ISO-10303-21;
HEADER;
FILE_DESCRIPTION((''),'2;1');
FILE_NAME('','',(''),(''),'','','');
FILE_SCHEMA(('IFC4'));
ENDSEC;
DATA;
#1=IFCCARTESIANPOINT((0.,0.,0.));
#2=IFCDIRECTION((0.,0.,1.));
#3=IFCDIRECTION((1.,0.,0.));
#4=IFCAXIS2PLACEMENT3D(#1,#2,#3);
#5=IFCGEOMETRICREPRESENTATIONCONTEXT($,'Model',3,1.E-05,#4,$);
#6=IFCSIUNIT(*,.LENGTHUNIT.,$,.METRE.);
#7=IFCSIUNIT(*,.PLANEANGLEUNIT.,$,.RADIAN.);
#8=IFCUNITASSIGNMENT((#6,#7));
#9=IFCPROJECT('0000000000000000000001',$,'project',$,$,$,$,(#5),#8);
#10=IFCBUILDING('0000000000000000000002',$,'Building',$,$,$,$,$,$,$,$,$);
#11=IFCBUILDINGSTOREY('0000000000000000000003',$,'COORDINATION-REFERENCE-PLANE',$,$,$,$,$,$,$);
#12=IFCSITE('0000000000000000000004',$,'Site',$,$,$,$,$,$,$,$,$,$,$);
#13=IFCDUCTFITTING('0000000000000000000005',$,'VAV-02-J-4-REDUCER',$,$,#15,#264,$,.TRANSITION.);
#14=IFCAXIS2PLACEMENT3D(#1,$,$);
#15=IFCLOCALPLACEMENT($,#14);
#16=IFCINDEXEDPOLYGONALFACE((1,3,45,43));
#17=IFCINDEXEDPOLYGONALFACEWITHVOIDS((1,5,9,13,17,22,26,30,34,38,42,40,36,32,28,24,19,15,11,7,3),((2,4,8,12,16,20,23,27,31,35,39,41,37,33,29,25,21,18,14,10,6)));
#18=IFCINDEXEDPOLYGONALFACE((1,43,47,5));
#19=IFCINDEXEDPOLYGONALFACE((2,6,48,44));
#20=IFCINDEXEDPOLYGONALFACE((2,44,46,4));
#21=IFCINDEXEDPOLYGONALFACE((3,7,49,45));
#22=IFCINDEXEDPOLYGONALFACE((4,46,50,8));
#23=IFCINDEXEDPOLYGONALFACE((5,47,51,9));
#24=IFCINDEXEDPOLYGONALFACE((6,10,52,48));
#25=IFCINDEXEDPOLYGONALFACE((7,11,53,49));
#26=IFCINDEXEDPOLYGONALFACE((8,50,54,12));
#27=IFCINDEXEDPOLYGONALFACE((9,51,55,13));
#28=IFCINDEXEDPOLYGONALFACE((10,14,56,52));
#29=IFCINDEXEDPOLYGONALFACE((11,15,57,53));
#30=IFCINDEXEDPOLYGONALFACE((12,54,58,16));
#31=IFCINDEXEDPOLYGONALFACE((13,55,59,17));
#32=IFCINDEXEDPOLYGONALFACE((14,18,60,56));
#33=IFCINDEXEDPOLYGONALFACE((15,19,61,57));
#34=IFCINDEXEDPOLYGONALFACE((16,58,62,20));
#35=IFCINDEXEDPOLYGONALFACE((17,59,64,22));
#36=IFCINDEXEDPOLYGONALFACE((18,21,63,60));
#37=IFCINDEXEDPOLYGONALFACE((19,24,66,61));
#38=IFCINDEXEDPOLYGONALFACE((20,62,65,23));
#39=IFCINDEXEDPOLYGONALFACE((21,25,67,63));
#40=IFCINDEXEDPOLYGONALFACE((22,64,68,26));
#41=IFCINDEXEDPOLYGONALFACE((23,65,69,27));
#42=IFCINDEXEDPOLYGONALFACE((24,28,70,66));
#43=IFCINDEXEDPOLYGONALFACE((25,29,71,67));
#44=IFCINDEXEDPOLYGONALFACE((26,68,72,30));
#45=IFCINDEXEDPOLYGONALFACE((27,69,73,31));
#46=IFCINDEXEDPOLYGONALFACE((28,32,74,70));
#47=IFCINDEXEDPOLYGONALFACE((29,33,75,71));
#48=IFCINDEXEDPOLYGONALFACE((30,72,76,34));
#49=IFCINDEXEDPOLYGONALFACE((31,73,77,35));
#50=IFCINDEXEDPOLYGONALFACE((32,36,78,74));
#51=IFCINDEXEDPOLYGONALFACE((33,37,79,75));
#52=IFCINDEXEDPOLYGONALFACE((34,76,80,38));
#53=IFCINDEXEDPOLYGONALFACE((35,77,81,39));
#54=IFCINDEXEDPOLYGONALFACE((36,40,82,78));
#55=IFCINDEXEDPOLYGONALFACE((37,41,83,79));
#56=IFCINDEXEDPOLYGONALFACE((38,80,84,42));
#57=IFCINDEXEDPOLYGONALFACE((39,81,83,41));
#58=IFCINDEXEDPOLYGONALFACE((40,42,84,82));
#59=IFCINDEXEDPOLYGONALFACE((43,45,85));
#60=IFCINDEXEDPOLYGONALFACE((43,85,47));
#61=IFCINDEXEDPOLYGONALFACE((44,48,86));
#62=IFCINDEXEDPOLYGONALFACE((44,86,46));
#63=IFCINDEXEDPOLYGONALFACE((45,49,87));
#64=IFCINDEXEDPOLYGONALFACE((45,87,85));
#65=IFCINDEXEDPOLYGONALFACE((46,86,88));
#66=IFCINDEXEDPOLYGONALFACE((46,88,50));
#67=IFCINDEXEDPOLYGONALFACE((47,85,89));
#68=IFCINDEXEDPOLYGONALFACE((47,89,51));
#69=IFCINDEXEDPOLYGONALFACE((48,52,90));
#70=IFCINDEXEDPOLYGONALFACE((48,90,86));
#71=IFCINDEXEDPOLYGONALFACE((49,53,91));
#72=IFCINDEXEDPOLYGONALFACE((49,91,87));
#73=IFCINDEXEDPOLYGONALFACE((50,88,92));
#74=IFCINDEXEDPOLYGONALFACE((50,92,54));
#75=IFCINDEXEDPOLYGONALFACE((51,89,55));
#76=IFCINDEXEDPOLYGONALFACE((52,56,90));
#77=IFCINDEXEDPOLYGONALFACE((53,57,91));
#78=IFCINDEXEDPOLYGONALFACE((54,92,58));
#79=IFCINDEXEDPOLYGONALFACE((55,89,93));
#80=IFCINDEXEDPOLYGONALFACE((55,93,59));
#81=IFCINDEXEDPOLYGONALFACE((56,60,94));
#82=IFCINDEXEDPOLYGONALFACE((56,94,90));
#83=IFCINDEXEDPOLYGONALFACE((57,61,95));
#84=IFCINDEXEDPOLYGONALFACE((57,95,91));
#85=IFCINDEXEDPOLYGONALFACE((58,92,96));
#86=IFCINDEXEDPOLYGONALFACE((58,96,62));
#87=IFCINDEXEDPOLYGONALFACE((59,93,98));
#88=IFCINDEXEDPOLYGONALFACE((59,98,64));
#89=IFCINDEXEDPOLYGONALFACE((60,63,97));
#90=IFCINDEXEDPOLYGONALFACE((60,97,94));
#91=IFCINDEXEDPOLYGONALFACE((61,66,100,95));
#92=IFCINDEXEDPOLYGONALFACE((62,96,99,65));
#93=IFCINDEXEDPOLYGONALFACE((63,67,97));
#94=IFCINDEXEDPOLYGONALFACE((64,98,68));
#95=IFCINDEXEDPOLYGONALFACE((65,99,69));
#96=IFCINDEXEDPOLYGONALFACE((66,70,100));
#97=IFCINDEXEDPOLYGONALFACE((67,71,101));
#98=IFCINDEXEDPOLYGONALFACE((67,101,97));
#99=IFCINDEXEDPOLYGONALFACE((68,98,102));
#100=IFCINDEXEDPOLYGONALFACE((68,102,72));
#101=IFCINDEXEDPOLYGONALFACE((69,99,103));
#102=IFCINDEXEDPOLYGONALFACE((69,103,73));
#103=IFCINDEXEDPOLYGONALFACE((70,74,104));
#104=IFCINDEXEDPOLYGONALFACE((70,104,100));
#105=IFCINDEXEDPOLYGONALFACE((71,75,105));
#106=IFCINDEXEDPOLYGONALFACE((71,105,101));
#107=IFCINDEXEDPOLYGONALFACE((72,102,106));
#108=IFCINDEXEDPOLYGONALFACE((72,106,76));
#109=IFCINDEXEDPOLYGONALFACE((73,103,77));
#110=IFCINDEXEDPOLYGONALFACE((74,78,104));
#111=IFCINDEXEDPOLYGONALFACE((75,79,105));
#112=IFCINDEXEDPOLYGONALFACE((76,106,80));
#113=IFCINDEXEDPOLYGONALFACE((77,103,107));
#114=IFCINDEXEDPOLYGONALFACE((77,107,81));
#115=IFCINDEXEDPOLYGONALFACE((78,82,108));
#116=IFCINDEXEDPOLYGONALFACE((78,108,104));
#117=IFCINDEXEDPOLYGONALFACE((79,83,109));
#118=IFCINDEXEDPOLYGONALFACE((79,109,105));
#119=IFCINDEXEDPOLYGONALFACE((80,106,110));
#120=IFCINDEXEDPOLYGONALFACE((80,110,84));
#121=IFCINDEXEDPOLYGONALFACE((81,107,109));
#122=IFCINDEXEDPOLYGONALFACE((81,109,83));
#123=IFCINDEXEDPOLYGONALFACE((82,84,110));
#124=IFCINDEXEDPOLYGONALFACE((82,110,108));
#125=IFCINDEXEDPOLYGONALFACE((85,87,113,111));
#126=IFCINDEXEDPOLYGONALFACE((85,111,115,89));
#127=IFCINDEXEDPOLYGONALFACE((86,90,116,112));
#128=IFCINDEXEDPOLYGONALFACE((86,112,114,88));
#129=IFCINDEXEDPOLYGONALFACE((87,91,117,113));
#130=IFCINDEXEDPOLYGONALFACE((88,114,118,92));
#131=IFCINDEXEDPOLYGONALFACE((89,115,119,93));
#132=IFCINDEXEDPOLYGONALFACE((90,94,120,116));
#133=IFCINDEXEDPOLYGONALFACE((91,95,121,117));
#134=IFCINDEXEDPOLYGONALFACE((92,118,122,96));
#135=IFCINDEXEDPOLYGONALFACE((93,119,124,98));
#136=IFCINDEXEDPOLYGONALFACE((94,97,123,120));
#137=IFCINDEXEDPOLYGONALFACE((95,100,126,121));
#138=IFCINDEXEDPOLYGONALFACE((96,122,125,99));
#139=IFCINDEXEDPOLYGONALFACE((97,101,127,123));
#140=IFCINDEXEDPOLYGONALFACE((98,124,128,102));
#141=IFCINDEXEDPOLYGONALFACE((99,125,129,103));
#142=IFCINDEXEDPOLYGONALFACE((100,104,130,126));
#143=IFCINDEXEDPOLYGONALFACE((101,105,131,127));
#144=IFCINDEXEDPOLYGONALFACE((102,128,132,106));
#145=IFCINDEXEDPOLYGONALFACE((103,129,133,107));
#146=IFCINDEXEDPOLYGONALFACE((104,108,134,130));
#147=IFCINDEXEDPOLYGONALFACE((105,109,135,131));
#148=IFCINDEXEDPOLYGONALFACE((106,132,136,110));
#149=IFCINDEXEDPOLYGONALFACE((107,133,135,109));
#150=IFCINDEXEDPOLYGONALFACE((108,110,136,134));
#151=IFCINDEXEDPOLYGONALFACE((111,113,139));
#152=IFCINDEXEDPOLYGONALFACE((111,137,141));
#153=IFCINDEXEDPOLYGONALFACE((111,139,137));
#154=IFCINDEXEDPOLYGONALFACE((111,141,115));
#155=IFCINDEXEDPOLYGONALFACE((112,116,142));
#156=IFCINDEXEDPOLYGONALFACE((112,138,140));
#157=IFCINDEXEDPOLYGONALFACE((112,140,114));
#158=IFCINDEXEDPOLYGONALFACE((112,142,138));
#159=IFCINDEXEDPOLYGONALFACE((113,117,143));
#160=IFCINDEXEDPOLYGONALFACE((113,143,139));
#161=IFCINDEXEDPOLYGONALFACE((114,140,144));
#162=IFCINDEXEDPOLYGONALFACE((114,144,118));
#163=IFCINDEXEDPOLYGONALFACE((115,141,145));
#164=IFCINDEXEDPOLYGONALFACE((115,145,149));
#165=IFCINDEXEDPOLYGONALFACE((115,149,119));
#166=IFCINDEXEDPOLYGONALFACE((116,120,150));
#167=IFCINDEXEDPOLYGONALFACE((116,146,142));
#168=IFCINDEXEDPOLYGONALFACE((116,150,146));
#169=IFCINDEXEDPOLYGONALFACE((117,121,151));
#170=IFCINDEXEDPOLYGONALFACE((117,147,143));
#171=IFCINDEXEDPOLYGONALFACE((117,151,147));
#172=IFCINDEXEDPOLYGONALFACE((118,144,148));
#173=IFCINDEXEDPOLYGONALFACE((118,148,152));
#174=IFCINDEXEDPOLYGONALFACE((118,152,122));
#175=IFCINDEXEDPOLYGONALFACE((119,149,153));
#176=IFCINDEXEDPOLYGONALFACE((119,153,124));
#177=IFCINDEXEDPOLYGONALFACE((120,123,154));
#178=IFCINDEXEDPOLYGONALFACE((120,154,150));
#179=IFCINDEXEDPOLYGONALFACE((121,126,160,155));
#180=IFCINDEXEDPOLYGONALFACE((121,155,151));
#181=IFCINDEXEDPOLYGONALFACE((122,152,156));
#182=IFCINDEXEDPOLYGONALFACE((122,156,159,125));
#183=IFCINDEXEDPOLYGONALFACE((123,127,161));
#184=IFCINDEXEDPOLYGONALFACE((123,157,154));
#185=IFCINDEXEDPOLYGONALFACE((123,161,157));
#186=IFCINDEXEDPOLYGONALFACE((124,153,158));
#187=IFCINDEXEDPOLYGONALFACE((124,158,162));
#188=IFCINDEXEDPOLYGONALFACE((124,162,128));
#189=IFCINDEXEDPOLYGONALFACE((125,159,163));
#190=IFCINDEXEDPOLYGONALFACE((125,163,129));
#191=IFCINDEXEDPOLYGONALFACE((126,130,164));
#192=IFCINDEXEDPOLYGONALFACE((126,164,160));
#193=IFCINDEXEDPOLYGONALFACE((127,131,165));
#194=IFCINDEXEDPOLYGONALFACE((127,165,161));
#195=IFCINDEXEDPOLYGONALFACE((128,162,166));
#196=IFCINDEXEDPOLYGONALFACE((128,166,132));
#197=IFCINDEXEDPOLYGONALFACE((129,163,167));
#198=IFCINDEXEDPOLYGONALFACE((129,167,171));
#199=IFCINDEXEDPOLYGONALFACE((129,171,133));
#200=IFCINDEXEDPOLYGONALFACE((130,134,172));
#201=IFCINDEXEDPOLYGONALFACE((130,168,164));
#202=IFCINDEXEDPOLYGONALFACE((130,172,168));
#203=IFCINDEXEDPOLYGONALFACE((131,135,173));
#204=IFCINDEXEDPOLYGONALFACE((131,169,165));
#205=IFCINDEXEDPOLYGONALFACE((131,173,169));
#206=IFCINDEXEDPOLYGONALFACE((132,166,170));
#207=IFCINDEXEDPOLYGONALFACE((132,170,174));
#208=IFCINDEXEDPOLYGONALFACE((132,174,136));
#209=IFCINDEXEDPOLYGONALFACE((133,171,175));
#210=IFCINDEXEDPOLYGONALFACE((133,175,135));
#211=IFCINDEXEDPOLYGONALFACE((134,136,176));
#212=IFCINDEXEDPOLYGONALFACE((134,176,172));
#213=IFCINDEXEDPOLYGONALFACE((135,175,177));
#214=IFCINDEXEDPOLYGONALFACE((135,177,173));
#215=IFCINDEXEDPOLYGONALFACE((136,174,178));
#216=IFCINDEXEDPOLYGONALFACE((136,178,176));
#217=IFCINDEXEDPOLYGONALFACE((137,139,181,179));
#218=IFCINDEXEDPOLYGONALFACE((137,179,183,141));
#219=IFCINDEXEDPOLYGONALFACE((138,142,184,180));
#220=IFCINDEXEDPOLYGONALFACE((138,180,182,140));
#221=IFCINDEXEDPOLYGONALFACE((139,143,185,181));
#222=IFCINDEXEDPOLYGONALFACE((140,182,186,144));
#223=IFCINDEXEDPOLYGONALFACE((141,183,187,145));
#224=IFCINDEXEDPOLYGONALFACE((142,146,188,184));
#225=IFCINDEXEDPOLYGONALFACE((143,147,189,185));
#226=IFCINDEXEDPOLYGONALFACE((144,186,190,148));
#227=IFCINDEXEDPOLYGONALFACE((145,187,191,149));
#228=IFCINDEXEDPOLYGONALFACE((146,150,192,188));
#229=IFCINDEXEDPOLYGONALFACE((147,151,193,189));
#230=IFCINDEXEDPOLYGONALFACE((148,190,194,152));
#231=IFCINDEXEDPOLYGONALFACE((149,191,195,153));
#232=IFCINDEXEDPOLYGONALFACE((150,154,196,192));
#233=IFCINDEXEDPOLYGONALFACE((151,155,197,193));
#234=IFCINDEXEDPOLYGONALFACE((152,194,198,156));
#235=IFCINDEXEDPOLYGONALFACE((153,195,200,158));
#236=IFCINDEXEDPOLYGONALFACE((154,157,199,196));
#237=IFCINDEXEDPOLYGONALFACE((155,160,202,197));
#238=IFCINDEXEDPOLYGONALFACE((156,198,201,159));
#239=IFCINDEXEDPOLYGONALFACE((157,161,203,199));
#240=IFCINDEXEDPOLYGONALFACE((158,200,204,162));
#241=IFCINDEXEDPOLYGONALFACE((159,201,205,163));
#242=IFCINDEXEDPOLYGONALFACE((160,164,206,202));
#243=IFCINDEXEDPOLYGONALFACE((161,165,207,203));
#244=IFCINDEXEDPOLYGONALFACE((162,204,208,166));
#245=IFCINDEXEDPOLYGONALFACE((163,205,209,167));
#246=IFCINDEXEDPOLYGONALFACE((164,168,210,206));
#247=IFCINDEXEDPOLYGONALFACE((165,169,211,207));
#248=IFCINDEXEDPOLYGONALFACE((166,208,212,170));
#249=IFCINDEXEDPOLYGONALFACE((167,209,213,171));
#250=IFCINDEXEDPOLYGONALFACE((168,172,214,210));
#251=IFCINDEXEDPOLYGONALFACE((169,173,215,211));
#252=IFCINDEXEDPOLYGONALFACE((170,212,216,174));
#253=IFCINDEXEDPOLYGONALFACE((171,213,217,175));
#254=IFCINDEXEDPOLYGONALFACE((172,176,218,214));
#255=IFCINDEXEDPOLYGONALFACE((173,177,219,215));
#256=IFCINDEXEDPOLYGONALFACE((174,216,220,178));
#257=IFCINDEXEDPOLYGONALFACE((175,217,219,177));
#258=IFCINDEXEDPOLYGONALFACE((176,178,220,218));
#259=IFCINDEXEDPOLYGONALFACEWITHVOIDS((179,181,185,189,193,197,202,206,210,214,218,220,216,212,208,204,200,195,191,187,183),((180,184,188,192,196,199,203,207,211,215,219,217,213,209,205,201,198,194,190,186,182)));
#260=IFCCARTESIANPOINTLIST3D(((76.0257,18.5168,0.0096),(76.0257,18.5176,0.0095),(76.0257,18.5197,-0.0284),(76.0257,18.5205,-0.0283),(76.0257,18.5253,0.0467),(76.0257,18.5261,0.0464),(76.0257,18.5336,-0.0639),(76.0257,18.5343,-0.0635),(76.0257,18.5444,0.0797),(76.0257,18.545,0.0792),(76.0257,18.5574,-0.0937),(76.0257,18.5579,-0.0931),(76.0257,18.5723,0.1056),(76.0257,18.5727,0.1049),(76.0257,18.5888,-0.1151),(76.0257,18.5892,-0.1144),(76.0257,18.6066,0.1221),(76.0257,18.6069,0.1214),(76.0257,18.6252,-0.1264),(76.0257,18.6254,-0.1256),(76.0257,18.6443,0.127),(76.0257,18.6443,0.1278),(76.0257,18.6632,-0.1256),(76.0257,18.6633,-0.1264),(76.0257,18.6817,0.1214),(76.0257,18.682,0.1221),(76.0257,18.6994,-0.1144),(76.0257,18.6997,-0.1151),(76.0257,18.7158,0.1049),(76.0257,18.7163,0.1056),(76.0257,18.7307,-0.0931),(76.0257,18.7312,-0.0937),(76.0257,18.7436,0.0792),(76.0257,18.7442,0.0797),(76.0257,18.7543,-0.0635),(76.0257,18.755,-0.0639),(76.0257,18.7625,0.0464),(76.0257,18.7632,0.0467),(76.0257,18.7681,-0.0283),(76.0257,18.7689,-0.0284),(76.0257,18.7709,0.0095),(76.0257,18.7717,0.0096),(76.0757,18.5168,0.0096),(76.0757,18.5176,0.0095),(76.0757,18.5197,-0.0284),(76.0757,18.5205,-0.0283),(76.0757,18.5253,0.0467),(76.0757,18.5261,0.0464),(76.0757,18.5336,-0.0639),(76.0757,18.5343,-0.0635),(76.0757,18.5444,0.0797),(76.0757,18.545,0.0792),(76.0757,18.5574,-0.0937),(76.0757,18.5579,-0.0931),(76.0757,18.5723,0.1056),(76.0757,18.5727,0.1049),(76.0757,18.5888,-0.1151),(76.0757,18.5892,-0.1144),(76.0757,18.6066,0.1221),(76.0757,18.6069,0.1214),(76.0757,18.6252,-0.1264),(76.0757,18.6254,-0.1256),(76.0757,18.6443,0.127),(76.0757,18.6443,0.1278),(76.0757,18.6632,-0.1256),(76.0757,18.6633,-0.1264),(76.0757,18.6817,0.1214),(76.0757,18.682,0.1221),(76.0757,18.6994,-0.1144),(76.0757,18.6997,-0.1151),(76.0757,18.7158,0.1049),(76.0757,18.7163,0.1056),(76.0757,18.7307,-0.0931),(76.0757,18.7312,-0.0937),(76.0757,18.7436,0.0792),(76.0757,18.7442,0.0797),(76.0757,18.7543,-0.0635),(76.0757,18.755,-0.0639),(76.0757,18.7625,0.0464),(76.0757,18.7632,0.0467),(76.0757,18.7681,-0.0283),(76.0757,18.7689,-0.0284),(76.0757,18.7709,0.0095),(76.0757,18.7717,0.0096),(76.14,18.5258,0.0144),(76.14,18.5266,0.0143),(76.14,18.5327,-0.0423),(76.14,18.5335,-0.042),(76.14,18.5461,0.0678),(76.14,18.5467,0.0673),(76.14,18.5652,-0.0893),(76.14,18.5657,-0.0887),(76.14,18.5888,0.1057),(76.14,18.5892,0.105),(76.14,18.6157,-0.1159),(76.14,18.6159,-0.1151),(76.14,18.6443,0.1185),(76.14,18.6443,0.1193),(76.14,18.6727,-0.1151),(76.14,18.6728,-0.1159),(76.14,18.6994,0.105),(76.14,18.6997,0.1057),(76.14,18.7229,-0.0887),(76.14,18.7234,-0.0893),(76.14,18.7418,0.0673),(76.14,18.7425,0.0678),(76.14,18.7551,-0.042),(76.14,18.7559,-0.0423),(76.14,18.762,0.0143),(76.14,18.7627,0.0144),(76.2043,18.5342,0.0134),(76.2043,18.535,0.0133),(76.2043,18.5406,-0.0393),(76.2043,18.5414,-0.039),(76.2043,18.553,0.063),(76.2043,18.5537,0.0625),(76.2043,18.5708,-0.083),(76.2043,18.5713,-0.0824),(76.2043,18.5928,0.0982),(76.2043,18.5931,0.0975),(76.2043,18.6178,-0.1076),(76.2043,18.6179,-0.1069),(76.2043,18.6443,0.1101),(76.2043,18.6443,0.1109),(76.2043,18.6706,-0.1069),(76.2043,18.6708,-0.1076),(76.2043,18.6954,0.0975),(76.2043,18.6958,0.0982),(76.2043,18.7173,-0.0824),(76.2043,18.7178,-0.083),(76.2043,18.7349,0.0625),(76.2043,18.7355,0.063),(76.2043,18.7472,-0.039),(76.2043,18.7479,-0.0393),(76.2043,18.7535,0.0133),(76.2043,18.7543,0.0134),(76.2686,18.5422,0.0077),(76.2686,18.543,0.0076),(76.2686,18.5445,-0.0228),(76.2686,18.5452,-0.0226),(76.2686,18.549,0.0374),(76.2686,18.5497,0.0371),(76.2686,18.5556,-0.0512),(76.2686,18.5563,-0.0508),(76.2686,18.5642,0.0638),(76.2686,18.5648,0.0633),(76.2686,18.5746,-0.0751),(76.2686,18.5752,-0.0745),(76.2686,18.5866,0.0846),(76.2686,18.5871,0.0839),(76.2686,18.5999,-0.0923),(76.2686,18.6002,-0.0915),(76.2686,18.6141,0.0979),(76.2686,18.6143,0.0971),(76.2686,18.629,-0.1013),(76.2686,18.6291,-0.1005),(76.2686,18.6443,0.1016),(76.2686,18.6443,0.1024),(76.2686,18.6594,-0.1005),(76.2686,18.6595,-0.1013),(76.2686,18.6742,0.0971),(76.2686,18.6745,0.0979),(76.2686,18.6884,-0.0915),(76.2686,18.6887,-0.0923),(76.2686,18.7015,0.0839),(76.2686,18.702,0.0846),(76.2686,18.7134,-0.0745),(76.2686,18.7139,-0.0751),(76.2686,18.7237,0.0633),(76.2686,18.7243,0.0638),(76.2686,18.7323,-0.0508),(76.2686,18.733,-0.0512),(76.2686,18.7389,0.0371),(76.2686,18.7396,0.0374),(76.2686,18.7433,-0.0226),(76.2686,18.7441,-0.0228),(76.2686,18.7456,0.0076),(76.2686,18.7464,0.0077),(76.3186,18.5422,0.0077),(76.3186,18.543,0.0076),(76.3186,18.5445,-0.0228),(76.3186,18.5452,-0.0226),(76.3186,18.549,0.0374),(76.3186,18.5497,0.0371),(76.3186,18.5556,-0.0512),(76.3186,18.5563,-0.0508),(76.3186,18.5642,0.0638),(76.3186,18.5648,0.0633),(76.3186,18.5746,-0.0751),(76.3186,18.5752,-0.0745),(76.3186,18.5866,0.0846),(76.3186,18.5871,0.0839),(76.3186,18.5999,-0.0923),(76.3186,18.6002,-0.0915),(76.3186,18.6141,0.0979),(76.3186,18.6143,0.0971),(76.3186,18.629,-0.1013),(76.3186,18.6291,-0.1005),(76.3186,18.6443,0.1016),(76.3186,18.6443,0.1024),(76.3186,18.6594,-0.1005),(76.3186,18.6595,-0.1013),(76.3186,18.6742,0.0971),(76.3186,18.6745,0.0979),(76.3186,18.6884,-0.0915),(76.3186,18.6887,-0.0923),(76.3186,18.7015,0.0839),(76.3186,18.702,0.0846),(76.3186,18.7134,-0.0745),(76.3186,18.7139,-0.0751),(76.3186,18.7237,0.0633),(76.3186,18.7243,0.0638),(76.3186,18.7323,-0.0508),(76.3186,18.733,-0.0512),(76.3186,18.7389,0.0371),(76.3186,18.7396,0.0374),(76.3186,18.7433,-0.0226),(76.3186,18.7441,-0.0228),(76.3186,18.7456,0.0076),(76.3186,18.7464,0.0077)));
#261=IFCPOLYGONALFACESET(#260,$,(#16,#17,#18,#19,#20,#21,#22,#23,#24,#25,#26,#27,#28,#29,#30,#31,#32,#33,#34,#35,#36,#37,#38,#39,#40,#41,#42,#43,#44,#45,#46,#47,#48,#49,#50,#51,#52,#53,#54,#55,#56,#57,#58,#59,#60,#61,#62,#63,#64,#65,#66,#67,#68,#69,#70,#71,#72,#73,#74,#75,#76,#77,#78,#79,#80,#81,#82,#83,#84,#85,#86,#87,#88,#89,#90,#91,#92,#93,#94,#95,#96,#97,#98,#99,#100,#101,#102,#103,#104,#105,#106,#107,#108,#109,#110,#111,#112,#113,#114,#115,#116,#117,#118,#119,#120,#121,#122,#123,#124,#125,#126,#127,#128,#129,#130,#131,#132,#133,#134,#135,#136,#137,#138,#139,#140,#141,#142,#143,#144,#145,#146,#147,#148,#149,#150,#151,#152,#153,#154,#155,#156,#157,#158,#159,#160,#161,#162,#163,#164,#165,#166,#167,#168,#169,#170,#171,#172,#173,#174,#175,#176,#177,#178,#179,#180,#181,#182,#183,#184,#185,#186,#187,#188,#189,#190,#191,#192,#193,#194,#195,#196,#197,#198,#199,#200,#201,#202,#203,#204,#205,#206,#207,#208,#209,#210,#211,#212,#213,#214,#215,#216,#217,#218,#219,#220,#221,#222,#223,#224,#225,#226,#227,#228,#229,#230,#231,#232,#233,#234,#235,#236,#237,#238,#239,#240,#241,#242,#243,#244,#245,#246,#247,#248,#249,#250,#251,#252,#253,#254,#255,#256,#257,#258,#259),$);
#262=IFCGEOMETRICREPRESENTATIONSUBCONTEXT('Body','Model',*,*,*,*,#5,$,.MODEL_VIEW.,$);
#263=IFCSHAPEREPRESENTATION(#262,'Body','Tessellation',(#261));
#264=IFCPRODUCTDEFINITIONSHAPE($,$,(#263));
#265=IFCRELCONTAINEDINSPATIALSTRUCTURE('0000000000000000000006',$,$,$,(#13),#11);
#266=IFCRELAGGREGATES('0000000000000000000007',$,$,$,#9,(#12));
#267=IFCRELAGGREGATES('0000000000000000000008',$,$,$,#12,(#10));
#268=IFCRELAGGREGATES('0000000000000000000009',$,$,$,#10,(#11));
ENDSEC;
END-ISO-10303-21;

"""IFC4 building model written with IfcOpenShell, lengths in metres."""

from ifc_helpers import new_model, entity, si_unit, frame, origin_with_axes, place, context, subcontext, project, spatial, element, save


model = new_model("IFC4")

# Units and contexts
model_context = context("Model", 3, precision=1e-05, world=origin_with_axes())
body_context_1 = subcontext(model_context, "Body", "Model", "MODEL_VIEW")
ifc_project = project(units=[si_unit("LENGTHUNIT", "METRE"), si_unit("PLANEANGLEUNIT", "RADIAN")], contexts=[model_context])

# Site, building, storey
site = spatial("IfcSite", under=ifc_project, Name="Site")
building = spatial("IfcBuilding", under=site, Name="Building")
storey = spatial("IfcBuildingStorey", under=building, Name="COORDINATION-REFERENCE-PLANE")

# Duct fitting
for number, where, z_axis, x_axis, name in (
    (1, (76.0257, 18.6443, 0.0), (0.0, 1.0, 0.0), (0.0, 0.0, 1.0), "VAV-02-J-4-REDUCER"),
):
    element("IfcDuctFitting", number, at=place(None, frame(where, z_axis=z_axis, x_axis=x_axis)), inside=storey, Name=name, PredefinedType="TRANSITION", context=body_context_1, shape_type="SweptSolid", body=[
        entity("IfcRevolvedAreaSolid", entity("IfcArbitraryClosedProfileDef", "AREA", None, entity("IfcPolyline", [entity("IfcCartesianPoint", [0.1278, 0.0]), entity("IfcCartesianPoint", [0.1278, 0.05]), entity("IfcCartesianPoint", [0.1024, 0.2429]), entity("IfcCartesianPoint", [0.1024, 0.2929]), entity("IfcCartesianPoint", [0.1016, 0.2929]), entity("IfcCartesianPoint", [0.1016, 0.2429]), entity("IfcCartesianPoint", [0.127, 0.05]), entity("IfcCartesianPoint", [0.127, 0.0]), entity("IfcCartesianPoint", [0.1278, 0.0])])), entity("IfcAxis2Placement3D", entity("IfcCartesianPoint", [0.0, 0.0, 0.0])), entity("IfcAxis1Placement", entity("IfcCartesianPoint", [0.0, 0.0, 0.0]), entity("IfcDirection", [0.0, 1.0, 0.0])), 6.283185),
    ])

save(model, "model.ifc")
